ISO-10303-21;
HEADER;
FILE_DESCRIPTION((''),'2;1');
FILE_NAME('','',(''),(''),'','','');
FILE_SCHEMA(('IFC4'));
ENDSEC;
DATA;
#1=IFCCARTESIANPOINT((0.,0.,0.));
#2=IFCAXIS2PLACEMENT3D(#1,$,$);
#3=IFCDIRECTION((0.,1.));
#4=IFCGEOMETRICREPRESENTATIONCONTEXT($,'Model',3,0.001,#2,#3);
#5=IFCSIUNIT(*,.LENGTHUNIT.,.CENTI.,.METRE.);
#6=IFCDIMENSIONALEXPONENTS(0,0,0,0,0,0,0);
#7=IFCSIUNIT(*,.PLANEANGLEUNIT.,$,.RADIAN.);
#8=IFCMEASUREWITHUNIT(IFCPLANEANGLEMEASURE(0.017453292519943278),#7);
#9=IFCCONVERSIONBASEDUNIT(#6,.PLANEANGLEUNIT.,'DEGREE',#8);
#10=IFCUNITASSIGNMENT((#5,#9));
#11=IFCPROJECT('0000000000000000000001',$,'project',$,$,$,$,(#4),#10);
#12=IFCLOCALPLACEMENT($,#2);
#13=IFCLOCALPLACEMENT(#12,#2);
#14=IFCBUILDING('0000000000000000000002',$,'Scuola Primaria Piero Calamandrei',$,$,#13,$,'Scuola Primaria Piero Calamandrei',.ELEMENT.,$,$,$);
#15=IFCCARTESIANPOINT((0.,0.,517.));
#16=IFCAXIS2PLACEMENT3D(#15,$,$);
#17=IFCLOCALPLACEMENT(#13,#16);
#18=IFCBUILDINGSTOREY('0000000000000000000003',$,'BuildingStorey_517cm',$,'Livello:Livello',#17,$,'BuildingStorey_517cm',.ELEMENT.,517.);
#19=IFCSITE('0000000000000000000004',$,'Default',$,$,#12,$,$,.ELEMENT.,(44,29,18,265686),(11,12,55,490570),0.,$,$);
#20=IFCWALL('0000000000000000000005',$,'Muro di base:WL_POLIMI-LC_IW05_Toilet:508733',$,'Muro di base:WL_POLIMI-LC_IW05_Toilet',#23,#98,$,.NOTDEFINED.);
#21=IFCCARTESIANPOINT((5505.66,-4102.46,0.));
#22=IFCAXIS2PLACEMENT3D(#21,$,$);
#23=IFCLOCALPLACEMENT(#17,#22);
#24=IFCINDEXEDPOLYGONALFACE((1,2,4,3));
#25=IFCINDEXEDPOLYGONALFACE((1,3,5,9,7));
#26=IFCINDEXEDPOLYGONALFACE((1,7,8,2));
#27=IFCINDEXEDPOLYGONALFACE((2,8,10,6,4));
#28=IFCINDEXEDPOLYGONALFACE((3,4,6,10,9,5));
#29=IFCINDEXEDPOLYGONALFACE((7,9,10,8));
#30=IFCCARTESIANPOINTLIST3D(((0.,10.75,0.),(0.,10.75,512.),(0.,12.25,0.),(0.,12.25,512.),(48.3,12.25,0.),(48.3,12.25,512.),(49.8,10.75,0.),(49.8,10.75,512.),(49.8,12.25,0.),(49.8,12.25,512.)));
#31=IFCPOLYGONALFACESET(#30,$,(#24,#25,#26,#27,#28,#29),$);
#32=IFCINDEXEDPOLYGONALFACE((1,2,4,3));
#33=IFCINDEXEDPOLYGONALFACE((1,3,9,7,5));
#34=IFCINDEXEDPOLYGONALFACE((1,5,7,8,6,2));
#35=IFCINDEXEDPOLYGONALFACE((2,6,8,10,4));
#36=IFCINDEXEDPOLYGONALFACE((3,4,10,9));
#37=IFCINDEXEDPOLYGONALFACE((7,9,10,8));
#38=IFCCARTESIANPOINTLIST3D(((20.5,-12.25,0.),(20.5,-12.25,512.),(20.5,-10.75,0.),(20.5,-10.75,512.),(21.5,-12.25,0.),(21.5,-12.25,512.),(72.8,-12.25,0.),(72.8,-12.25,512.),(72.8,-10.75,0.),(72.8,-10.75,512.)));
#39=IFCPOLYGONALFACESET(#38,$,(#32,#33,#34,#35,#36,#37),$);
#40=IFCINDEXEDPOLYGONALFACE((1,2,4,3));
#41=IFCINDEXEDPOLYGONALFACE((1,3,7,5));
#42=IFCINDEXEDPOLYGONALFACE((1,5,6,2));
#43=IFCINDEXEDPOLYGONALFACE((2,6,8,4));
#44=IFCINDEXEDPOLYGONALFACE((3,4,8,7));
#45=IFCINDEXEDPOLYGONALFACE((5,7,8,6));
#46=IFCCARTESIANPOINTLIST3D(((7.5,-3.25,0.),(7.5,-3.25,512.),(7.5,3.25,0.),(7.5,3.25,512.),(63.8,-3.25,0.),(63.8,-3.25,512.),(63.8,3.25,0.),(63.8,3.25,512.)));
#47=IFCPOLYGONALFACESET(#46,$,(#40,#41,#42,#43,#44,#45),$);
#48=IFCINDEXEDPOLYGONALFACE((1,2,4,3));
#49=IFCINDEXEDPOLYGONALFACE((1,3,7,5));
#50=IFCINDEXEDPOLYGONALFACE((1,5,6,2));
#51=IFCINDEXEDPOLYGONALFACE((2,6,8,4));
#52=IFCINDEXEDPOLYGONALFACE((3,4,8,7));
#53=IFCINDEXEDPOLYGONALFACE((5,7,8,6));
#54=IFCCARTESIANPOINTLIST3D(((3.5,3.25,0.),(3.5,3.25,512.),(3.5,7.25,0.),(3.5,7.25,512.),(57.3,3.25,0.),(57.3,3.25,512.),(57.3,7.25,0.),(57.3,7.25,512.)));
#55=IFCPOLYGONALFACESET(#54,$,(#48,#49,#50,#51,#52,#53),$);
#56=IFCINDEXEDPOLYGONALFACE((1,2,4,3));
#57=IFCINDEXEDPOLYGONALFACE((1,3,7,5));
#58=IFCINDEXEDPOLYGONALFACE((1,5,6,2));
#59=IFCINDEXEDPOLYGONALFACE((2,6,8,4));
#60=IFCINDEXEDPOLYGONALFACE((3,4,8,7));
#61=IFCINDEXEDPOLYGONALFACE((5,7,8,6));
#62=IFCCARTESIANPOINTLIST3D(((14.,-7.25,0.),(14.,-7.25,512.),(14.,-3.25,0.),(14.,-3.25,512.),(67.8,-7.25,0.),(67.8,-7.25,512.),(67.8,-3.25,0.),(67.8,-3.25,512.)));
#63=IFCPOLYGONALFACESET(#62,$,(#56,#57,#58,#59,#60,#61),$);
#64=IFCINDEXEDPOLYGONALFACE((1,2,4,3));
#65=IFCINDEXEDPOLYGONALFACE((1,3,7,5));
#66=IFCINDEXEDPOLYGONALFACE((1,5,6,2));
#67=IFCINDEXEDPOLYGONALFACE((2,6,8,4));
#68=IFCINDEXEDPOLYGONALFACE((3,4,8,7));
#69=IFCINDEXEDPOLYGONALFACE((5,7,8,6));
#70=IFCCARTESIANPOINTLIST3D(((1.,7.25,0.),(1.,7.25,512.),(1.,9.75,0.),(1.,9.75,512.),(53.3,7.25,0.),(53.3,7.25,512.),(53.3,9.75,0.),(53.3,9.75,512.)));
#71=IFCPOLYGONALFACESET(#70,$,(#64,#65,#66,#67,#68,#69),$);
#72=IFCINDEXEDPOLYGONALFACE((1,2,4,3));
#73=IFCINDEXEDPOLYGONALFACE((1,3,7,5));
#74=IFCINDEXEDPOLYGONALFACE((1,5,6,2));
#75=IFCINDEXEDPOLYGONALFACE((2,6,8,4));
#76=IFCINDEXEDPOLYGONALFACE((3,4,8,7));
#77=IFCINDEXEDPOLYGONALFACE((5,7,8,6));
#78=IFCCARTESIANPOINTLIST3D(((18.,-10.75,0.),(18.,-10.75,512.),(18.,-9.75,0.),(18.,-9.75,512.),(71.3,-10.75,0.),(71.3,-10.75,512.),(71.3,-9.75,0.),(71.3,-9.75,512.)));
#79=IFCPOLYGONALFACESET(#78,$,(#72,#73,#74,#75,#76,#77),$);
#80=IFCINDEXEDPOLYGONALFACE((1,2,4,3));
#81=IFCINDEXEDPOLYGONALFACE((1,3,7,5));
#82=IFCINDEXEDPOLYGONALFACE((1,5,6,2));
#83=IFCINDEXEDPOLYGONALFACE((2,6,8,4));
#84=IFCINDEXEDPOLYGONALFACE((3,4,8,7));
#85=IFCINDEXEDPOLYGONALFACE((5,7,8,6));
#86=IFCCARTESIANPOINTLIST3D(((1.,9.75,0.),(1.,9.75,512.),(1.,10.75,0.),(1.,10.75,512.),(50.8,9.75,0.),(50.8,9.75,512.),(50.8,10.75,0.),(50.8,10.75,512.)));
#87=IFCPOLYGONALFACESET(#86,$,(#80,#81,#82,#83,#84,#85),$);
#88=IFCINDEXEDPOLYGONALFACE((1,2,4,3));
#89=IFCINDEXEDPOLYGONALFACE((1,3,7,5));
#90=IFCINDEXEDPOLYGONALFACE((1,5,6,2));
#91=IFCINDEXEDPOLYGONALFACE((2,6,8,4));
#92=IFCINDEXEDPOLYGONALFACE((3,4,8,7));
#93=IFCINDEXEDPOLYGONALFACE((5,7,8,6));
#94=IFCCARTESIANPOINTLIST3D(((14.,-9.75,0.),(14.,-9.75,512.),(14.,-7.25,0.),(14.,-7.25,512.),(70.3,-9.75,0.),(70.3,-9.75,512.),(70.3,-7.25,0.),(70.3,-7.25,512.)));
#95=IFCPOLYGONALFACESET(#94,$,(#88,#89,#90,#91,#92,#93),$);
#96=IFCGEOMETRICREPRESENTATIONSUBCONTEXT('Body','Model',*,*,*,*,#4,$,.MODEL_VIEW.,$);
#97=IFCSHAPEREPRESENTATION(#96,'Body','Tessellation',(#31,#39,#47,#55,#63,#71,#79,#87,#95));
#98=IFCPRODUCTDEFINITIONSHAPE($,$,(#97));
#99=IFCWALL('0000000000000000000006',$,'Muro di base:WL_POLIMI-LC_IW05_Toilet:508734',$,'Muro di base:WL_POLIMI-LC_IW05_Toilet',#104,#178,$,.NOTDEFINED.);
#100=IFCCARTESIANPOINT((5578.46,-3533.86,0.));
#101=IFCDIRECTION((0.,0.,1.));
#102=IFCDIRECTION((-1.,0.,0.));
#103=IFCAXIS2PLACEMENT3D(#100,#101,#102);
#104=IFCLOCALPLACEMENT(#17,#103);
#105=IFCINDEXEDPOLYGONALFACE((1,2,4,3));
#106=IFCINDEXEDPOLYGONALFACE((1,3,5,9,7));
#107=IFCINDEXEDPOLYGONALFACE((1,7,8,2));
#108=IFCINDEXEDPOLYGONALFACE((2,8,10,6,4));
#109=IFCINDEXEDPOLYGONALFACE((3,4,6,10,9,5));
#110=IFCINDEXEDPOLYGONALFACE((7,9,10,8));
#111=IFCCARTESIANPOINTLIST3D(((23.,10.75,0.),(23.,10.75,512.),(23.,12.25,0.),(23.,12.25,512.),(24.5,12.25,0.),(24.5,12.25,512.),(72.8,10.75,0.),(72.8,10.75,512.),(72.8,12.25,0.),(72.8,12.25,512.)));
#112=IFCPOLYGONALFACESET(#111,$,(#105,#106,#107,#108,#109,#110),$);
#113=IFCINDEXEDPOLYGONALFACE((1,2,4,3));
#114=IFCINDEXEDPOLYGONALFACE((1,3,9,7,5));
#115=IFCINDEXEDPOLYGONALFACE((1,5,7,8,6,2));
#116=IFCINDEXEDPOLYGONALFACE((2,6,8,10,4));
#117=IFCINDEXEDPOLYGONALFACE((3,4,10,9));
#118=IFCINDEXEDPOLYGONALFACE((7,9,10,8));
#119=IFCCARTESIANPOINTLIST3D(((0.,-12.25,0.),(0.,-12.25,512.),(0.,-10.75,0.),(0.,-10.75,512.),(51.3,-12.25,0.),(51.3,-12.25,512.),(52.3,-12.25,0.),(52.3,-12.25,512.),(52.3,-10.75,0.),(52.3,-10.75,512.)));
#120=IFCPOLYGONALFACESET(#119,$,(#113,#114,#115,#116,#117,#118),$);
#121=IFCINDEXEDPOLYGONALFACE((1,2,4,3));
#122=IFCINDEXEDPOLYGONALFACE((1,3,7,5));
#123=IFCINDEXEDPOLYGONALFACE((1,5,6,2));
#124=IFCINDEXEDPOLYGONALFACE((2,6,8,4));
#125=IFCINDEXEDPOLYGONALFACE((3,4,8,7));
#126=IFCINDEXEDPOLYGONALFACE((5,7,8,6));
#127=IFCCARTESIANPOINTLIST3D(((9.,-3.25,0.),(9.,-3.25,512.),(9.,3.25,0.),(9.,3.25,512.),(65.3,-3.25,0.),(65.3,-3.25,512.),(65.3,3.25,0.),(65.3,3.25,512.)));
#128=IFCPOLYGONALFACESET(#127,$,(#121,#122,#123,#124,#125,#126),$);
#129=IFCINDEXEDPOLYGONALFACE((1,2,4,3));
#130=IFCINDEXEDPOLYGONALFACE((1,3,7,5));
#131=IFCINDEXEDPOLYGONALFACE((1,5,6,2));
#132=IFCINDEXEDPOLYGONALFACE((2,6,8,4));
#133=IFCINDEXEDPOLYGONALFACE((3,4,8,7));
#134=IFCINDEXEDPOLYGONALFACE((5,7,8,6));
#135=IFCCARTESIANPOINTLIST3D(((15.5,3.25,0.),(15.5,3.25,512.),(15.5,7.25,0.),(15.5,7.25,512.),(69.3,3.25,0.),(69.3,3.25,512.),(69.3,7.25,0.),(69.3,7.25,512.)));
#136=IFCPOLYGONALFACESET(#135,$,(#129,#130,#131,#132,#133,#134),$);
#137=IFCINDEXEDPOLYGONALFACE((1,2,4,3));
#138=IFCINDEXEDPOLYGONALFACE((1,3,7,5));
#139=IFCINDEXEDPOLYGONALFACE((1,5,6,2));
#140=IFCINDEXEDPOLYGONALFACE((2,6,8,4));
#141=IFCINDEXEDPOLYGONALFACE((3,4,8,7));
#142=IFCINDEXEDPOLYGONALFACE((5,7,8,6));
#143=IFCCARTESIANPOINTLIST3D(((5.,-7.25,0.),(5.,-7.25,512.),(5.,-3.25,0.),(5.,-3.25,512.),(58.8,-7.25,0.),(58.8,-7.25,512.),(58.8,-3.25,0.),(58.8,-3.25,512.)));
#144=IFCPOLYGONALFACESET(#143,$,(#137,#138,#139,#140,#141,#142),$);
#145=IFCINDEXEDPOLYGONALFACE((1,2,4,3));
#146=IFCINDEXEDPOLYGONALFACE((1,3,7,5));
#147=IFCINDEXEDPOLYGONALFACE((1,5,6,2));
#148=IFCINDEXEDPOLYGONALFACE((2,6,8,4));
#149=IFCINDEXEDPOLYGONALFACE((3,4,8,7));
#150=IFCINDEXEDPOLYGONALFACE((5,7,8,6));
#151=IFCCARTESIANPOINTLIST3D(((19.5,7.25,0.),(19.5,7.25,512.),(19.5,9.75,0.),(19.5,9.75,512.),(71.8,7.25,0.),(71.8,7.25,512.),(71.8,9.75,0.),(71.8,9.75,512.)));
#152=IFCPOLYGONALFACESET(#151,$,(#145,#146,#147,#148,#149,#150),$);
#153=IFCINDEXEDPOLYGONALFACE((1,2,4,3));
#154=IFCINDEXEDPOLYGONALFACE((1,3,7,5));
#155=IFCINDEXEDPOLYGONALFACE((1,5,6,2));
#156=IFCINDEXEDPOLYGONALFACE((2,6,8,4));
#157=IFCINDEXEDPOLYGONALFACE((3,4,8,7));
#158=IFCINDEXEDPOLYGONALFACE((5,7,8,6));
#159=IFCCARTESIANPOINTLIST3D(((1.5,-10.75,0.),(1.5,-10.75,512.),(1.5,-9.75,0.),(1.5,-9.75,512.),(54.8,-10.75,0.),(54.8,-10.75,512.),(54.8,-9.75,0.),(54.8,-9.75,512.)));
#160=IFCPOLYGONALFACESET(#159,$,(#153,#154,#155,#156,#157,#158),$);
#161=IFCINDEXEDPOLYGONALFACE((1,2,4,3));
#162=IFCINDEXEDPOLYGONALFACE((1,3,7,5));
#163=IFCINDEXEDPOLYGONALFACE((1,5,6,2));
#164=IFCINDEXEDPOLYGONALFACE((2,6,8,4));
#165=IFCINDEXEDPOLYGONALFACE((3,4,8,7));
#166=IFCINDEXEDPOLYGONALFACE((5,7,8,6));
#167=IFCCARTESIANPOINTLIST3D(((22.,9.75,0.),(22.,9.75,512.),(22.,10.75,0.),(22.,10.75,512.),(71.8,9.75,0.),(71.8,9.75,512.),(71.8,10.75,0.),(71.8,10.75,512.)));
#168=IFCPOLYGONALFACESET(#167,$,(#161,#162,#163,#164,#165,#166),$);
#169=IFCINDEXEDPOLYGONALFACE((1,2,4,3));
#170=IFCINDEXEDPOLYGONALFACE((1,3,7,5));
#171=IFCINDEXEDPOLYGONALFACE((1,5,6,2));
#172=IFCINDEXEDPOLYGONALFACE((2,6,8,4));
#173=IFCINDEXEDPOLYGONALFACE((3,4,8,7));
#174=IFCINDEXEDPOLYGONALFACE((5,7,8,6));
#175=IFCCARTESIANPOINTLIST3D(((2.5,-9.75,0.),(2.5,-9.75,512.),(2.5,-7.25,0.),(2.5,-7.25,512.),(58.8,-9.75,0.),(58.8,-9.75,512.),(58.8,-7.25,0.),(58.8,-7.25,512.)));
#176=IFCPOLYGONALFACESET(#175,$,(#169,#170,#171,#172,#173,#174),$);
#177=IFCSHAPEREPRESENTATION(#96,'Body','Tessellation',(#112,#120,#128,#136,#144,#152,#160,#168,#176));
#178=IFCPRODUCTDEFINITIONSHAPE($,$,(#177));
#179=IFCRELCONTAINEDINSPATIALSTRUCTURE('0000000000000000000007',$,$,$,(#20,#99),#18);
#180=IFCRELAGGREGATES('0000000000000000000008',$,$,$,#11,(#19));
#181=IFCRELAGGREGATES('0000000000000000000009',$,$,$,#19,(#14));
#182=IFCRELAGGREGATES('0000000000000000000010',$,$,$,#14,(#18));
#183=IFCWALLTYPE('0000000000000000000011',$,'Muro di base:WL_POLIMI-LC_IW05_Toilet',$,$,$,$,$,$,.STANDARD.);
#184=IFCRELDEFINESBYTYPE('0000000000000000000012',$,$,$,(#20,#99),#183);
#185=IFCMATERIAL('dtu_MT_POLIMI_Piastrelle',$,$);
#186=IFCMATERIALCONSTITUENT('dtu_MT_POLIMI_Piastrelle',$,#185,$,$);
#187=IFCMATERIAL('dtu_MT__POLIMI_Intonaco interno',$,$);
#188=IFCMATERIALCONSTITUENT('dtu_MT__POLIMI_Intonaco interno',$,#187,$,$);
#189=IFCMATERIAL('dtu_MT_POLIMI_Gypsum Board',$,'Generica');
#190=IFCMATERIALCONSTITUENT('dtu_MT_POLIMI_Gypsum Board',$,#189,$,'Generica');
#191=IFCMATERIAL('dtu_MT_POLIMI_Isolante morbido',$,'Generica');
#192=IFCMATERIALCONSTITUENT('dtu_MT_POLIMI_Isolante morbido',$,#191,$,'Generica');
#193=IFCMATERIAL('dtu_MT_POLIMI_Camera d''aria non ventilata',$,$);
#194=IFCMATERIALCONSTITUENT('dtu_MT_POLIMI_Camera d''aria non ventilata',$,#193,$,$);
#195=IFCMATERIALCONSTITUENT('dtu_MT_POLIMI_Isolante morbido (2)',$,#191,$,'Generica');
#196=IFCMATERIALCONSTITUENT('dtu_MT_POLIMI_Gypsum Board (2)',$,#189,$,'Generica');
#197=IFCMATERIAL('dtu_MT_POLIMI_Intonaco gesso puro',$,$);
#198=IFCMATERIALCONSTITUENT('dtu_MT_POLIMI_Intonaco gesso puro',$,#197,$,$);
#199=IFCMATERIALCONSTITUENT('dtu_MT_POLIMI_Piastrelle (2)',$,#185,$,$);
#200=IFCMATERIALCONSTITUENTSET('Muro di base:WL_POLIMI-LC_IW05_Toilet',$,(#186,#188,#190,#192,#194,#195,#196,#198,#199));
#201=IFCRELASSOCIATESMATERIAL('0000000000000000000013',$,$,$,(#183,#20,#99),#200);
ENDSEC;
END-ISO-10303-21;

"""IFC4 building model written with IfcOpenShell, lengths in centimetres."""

from ifc_helpers import new_model, entity, si_unit, converted_unit, direction, frame, origin, place, context, subcontext, project, spatial, indexed_curve, outline, extrude, material, constituent, constituent_set, type_object, element, save


model = new_model("IFC4")

# Units and contexts
model_context = context("Model", 3, precision=0.001, world=origin(), true_north=direction((0.0, 1.0)))
body_context = subcontext(model_context, "Body", "Model", "MODEL_VIEW")
ifc_project = project(units=[si_unit("LENGTHUNIT", "METRE", prefix="CENTI"), converted_unit("PLANEANGLEUNIT", "DEGREE", entity("IfcPlaneAngleMeasure", 0.017453292519943278), si_unit("PLANEANGLEUNIT", "RADIAN"), dimensions=[0, 0, 0, 0, 0, 0, 0])], contexts=[model_context])

# Site, building, storey
site_placement = place(None, origin())
site = spatial("IfcSite", under=ifc_project, at=site_placement, Name="Default", CompositionType="ELEMENT", RefLatitude=(44, 29, 18, 265686), RefLongitude=(11, 12, 55, 490570), RefElevation=0.0)
building_placement = place(site_placement, origin())
building = spatial("IfcBuilding", under=site, at=building_placement, Name="Scuola Primaria Piero Calamandrei", LongName="Scuola Primaria Piero Calamandrei", CompositionType="ELEMENT")
storey_placement = place(building_placement, frame((0.0, 0.0, 517.0)))
storey = spatial("IfcBuildingStorey", under=building, at=storey_placement, Name="BuildingStorey_517cm", ObjectType="Livello:Livello", LongName="BuildingStorey_517cm", CompositionType="ELEMENT", Elevation=517.0)

# Shared definitions
ifc_material_1 = material(Name="dtu_MT_POLIMI_Isolante morbido", Category="Generica")
ifc_material_2 = material(Name="dtu_MT_POLIMI_Gypsum Board", Category="Generica")
ifc_material_3 = material(Name="dtu_MT__POLIMI_Intonaco interno")

# Shared definitions
ifc_material_4 = material(Name="dtu_MT_POLIMI_Camera d'aria non ventilata")
ifc_material_5 = material(Name="dtu_MT_POLIMI_Intonaco gesso puro")

# Walls
ifc_material_6 = material(Name="dtu_MT_POLIMI_Piastrelle")
ifc_constituent_1 = constituent(ifc_material_6, Name="dtu_MT_POLIMI_Piastrelle")
ifc_constituent_2 = constituent(ifc_material_3, Name="dtu_MT__POLIMI_Intonaco interno")
ifc_constituent_3 = constituent(ifc_material_2, Name="dtu_MT_POLIMI_Gypsum Board", Category="Generica")
ifc_constituent_4 = constituent(ifc_material_1, Name="dtu_MT_POLIMI_Isolante morbido", Category="Generica")
ifc_constituent_5 = constituent(ifc_material_4, Name="dtu_MT_POLIMI_Camera d'aria non ventilata")
ifc_constituent_6 = constituent(ifc_material_1, Name="dtu_MT_POLIMI_Isolante morbido (2)", Category="Generica")
ifc_constituent_7 = constituent(ifc_material_2, Name="dtu_MT_POLIMI_Gypsum Board (2)", Category="Generica")
ifc_constituent_8 = constituent(ifc_material_5, Name="dtu_MT_POLIMI_Intonaco gesso puro")
ifc_constituent_9 = constituent(ifc_material_6, Name="dtu_MT_POLIMI_Piastrelle (2)")
ifc_constituent_set_1 = constituent_set(constituents=[ifc_constituent_1, ifc_constituent_2, ifc_constituent_3, ifc_constituent_4, ifc_constituent_5, ifc_constituent_6, ifc_constituent_7, ifc_constituent_8, ifc_constituent_9], Name="Muro di base:WL_POLIMI-LC_IW05_Toilet")
wall_type_1 = type_object("IfcWallType", Name="Muro di base:WL_POLIMI-LC_IW05_Toilet", PredefinedType="STANDARD", material=ifc_constituent_set_1)
wall_1_placement = place(storey_placement, frame((5505.66, -4102.46, 0.0)))
element("IfcWall", 1, at=wall_1_placement, inside=storey, type_object=wall_type_1, material=ifc_constituent_set_1, Name="Muro di base:WL_POLIMI-LC_IW05_Toilet:508733", ObjectType="Muro di base:WL_POLIMI-LC_IW05_Toilet", PredefinedType="NOTDEFINED", context=body_context, shape_type="SweptSolid", body=[
    extrude(outline(indexed_curve([(-18.72, -0.6), (29.58, -0.6), (29.58, 0.9), (-20.22, 0.9), (-20.22, -0.6), (-18.72, -0.6)], self_intersect=False)), frame((29.58, 11.65, 0.0), z_axis=(0.0, 0.0, 1.0), x_axis=(-1.0, 0.0, 0.0)), (0.0, 0.0, 1.0), 512.0),
    extrude(outline(indexed_curve([(-20.12, -0.6), (31.18, -0.6), (31.18, 0.9), (-21.12, 0.9), (-21.12, -0.6), (-20.12, -0.6)], self_intersect=False)), frame((41.62, -11.65, 0.0)), (0.0, 0.0, 1.0), 512.0),
    extrude(outline(indexed_curve([(-28.15, -3.25), (28.15, -3.25), (28.15, 3.25), (-28.15, 3.25), (-28.15, -3.25)], self_intersect=False)), frame((35.65, 0.0, 0.0)), (0.0, 0.0, 1.0), 512.0),
    extrude(outline(indexed_curve([(-26.9, -2.0), (26.9, -2.0), (26.9, 2.0), (-26.9, 2.0), (-26.9, -2.0)], self_intersect=False)), frame((30.4, 5.25, 0.0)), (0.0, 0.0, 1.0), 512.0),
    extrude(outline(indexed_curve([(-26.9, -2.0), (26.9, -2.0), (26.9, 2.0), (-26.9, 2.0), (-26.9, -2.0)], self_intersect=False)), frame((40.9, -5.25, 0.0)), (0.0, 0.0, 1.0), 512.0),
    extrude(outline(indexed_curve([(-26.15, -1.25), (26.15, -1.25), (26.15, 1.25), (-26.15, 1.25), (-26.15, -1.25)], self_intersect=False)), frame((27.15, 8.5, 0.0)), (0.0, 0.0, 1.0), 512.0),
    extrude(outline(indexed_curve([(-26.65, -0.5), (26.65, -0.5), (26.65, 0.5), (-26.65, 0.5), (-26.65, -0.5)], self_intersect=False)), frame((44.65, -10.25, 0.0)), (0.0, 0.0, 1.0), 512.0),
    extrude(outline(indexed_curve([(-24.9, -0.5), (24.9, -0.5), (24.9, 0.5), (-24.9, 0.5), (-24.9, -0.5)], self_intersect=False)), frame((25.9, 10.25, 0.0)), (0.0, 0.0, 1.0), 512.0),
    extrude(outline(indexed_curve([(-28.15, -1.25), (28.15, -1.25), (28.15, 1.25), (-28.15, 1.25), (-28.15, -1.25)], self_intersect=False)), frame((42.15, -8.5, 0.0)), (0.0, 0.0, 1.0), 512.0),
])
wall_2_placement = place(storey_placement, frame((5578.46, -3533.86, 0.0), z_axis=(0.0, 0.0, 1.0), x_axis=(-1.0, 0.0, 0.0)))
element("IfcWall", 2, at=wall_2_placement, inside=storey, type_object=wall_type_1, material=ifc_constituent_set_1, Name="Muro di base:WL_POLIMI-LC_IW05_Toilet:508734", ObjectType="Muro di base:WL_POLIMI-LC_IW05_Toilet", PredefinedType="NOTDEFINED", context=body_context, shape_type="SweptSolid", body=[
    extrude(outline(indexed_curve([(18.72, -0.6), (20.22, -0.6), (20.22, 0.9), (-29.58, 0.9), (-29.58, -0.6), (18.72, -0.6)], self_intersect=False)), frame((43.22, 11.65, 0.0), z_axis=(0.0, 0.0, 1.0), x_axis=(-1.0, 0.0, 0.0)), (0.0, 0.0, 1.0), 512.0),
    extrude(outline(indexed_curve([(20.12, -0.6), (21.12, -0.6), (21.12, 0.9), (-31.18, 0.9), (-31.18, -0.6), (20.12, -0.6)], self_intersect=False)), frame((31.18, -11.65, 0.0)), (0.0, 0.0, 1.0), 512.0),
    extrude(outline(indexed_curve([(-28.15, -3.25), (28.15, -3.25), (28.15, 3.25), (-28.15, 3.25), (-28.15, -3.25)], self_intersect=False)), frame((37.15, 0.0, 0.0)), (0.0, 0.0, 1.0), 512.0),
    extrude(outline(indexed_curve([(-26.9, -2.0), (26.9, -2.0), (26.9, 2.0), (-26.9, 2.0), (-26.9, -2.0)], self_intersect=False)), frame((42.4, 5.25, 0.0)), (0.0, 0.0, 1.0), 512.0),
    extrude(outline(indexed_curve([(-26.9, -2.0), (26.9, -2.0), (26.9, 2.0), (-26.9, 2.0), (-26.9, -2.0)], self_intersect=False)), frame((31.9, -5.25, 0.0)), (0.0, 0.0, 1.0), 512.0),
    extrude(outline(indexed_curve([(-26.15, -1.25), (26.15, -1.25), (26.15, 1.25), (-26.15, 1.25), (-26.15, -1.25)], self_intersect=False)), frame((45.65, 8.5, 0.0)), (0.0, 0.0, 1.0), 512.0),
    extrude(outline(indexed_curve([(-26.65, -0.5), (26.65, -0.5), (26.65, 0.5), (-26.65, 0.5), (-26.65, -0.5)], self_intersect=False)), frame((28.15, -10.25, 0.0)), (0.0, 0.0, 1.0), 512.0),
    extrude(outline(indexed_curve([(-24.9, -0.5), (24.9, -0.5), (24.9, 0.5), (-24.9, 0.5), (-24.9, -0.5)], self_intersect=False)), frame((46.9, 10.25, 0.0)), (0.0, 0.0, 1.0), 512.0),
    extrude(outline(indexed_curve([(-28.15, -1.25), (28.15, -1.25), (28.15, 1.25), (-28.15, 1.25), (-28.15, -1.25)], self_intersect=False)), frame((30.65, -8.5, 0.0)), (0.0, 0.0, 1.0), 512.0),
])

save(model, "model.ifc")
